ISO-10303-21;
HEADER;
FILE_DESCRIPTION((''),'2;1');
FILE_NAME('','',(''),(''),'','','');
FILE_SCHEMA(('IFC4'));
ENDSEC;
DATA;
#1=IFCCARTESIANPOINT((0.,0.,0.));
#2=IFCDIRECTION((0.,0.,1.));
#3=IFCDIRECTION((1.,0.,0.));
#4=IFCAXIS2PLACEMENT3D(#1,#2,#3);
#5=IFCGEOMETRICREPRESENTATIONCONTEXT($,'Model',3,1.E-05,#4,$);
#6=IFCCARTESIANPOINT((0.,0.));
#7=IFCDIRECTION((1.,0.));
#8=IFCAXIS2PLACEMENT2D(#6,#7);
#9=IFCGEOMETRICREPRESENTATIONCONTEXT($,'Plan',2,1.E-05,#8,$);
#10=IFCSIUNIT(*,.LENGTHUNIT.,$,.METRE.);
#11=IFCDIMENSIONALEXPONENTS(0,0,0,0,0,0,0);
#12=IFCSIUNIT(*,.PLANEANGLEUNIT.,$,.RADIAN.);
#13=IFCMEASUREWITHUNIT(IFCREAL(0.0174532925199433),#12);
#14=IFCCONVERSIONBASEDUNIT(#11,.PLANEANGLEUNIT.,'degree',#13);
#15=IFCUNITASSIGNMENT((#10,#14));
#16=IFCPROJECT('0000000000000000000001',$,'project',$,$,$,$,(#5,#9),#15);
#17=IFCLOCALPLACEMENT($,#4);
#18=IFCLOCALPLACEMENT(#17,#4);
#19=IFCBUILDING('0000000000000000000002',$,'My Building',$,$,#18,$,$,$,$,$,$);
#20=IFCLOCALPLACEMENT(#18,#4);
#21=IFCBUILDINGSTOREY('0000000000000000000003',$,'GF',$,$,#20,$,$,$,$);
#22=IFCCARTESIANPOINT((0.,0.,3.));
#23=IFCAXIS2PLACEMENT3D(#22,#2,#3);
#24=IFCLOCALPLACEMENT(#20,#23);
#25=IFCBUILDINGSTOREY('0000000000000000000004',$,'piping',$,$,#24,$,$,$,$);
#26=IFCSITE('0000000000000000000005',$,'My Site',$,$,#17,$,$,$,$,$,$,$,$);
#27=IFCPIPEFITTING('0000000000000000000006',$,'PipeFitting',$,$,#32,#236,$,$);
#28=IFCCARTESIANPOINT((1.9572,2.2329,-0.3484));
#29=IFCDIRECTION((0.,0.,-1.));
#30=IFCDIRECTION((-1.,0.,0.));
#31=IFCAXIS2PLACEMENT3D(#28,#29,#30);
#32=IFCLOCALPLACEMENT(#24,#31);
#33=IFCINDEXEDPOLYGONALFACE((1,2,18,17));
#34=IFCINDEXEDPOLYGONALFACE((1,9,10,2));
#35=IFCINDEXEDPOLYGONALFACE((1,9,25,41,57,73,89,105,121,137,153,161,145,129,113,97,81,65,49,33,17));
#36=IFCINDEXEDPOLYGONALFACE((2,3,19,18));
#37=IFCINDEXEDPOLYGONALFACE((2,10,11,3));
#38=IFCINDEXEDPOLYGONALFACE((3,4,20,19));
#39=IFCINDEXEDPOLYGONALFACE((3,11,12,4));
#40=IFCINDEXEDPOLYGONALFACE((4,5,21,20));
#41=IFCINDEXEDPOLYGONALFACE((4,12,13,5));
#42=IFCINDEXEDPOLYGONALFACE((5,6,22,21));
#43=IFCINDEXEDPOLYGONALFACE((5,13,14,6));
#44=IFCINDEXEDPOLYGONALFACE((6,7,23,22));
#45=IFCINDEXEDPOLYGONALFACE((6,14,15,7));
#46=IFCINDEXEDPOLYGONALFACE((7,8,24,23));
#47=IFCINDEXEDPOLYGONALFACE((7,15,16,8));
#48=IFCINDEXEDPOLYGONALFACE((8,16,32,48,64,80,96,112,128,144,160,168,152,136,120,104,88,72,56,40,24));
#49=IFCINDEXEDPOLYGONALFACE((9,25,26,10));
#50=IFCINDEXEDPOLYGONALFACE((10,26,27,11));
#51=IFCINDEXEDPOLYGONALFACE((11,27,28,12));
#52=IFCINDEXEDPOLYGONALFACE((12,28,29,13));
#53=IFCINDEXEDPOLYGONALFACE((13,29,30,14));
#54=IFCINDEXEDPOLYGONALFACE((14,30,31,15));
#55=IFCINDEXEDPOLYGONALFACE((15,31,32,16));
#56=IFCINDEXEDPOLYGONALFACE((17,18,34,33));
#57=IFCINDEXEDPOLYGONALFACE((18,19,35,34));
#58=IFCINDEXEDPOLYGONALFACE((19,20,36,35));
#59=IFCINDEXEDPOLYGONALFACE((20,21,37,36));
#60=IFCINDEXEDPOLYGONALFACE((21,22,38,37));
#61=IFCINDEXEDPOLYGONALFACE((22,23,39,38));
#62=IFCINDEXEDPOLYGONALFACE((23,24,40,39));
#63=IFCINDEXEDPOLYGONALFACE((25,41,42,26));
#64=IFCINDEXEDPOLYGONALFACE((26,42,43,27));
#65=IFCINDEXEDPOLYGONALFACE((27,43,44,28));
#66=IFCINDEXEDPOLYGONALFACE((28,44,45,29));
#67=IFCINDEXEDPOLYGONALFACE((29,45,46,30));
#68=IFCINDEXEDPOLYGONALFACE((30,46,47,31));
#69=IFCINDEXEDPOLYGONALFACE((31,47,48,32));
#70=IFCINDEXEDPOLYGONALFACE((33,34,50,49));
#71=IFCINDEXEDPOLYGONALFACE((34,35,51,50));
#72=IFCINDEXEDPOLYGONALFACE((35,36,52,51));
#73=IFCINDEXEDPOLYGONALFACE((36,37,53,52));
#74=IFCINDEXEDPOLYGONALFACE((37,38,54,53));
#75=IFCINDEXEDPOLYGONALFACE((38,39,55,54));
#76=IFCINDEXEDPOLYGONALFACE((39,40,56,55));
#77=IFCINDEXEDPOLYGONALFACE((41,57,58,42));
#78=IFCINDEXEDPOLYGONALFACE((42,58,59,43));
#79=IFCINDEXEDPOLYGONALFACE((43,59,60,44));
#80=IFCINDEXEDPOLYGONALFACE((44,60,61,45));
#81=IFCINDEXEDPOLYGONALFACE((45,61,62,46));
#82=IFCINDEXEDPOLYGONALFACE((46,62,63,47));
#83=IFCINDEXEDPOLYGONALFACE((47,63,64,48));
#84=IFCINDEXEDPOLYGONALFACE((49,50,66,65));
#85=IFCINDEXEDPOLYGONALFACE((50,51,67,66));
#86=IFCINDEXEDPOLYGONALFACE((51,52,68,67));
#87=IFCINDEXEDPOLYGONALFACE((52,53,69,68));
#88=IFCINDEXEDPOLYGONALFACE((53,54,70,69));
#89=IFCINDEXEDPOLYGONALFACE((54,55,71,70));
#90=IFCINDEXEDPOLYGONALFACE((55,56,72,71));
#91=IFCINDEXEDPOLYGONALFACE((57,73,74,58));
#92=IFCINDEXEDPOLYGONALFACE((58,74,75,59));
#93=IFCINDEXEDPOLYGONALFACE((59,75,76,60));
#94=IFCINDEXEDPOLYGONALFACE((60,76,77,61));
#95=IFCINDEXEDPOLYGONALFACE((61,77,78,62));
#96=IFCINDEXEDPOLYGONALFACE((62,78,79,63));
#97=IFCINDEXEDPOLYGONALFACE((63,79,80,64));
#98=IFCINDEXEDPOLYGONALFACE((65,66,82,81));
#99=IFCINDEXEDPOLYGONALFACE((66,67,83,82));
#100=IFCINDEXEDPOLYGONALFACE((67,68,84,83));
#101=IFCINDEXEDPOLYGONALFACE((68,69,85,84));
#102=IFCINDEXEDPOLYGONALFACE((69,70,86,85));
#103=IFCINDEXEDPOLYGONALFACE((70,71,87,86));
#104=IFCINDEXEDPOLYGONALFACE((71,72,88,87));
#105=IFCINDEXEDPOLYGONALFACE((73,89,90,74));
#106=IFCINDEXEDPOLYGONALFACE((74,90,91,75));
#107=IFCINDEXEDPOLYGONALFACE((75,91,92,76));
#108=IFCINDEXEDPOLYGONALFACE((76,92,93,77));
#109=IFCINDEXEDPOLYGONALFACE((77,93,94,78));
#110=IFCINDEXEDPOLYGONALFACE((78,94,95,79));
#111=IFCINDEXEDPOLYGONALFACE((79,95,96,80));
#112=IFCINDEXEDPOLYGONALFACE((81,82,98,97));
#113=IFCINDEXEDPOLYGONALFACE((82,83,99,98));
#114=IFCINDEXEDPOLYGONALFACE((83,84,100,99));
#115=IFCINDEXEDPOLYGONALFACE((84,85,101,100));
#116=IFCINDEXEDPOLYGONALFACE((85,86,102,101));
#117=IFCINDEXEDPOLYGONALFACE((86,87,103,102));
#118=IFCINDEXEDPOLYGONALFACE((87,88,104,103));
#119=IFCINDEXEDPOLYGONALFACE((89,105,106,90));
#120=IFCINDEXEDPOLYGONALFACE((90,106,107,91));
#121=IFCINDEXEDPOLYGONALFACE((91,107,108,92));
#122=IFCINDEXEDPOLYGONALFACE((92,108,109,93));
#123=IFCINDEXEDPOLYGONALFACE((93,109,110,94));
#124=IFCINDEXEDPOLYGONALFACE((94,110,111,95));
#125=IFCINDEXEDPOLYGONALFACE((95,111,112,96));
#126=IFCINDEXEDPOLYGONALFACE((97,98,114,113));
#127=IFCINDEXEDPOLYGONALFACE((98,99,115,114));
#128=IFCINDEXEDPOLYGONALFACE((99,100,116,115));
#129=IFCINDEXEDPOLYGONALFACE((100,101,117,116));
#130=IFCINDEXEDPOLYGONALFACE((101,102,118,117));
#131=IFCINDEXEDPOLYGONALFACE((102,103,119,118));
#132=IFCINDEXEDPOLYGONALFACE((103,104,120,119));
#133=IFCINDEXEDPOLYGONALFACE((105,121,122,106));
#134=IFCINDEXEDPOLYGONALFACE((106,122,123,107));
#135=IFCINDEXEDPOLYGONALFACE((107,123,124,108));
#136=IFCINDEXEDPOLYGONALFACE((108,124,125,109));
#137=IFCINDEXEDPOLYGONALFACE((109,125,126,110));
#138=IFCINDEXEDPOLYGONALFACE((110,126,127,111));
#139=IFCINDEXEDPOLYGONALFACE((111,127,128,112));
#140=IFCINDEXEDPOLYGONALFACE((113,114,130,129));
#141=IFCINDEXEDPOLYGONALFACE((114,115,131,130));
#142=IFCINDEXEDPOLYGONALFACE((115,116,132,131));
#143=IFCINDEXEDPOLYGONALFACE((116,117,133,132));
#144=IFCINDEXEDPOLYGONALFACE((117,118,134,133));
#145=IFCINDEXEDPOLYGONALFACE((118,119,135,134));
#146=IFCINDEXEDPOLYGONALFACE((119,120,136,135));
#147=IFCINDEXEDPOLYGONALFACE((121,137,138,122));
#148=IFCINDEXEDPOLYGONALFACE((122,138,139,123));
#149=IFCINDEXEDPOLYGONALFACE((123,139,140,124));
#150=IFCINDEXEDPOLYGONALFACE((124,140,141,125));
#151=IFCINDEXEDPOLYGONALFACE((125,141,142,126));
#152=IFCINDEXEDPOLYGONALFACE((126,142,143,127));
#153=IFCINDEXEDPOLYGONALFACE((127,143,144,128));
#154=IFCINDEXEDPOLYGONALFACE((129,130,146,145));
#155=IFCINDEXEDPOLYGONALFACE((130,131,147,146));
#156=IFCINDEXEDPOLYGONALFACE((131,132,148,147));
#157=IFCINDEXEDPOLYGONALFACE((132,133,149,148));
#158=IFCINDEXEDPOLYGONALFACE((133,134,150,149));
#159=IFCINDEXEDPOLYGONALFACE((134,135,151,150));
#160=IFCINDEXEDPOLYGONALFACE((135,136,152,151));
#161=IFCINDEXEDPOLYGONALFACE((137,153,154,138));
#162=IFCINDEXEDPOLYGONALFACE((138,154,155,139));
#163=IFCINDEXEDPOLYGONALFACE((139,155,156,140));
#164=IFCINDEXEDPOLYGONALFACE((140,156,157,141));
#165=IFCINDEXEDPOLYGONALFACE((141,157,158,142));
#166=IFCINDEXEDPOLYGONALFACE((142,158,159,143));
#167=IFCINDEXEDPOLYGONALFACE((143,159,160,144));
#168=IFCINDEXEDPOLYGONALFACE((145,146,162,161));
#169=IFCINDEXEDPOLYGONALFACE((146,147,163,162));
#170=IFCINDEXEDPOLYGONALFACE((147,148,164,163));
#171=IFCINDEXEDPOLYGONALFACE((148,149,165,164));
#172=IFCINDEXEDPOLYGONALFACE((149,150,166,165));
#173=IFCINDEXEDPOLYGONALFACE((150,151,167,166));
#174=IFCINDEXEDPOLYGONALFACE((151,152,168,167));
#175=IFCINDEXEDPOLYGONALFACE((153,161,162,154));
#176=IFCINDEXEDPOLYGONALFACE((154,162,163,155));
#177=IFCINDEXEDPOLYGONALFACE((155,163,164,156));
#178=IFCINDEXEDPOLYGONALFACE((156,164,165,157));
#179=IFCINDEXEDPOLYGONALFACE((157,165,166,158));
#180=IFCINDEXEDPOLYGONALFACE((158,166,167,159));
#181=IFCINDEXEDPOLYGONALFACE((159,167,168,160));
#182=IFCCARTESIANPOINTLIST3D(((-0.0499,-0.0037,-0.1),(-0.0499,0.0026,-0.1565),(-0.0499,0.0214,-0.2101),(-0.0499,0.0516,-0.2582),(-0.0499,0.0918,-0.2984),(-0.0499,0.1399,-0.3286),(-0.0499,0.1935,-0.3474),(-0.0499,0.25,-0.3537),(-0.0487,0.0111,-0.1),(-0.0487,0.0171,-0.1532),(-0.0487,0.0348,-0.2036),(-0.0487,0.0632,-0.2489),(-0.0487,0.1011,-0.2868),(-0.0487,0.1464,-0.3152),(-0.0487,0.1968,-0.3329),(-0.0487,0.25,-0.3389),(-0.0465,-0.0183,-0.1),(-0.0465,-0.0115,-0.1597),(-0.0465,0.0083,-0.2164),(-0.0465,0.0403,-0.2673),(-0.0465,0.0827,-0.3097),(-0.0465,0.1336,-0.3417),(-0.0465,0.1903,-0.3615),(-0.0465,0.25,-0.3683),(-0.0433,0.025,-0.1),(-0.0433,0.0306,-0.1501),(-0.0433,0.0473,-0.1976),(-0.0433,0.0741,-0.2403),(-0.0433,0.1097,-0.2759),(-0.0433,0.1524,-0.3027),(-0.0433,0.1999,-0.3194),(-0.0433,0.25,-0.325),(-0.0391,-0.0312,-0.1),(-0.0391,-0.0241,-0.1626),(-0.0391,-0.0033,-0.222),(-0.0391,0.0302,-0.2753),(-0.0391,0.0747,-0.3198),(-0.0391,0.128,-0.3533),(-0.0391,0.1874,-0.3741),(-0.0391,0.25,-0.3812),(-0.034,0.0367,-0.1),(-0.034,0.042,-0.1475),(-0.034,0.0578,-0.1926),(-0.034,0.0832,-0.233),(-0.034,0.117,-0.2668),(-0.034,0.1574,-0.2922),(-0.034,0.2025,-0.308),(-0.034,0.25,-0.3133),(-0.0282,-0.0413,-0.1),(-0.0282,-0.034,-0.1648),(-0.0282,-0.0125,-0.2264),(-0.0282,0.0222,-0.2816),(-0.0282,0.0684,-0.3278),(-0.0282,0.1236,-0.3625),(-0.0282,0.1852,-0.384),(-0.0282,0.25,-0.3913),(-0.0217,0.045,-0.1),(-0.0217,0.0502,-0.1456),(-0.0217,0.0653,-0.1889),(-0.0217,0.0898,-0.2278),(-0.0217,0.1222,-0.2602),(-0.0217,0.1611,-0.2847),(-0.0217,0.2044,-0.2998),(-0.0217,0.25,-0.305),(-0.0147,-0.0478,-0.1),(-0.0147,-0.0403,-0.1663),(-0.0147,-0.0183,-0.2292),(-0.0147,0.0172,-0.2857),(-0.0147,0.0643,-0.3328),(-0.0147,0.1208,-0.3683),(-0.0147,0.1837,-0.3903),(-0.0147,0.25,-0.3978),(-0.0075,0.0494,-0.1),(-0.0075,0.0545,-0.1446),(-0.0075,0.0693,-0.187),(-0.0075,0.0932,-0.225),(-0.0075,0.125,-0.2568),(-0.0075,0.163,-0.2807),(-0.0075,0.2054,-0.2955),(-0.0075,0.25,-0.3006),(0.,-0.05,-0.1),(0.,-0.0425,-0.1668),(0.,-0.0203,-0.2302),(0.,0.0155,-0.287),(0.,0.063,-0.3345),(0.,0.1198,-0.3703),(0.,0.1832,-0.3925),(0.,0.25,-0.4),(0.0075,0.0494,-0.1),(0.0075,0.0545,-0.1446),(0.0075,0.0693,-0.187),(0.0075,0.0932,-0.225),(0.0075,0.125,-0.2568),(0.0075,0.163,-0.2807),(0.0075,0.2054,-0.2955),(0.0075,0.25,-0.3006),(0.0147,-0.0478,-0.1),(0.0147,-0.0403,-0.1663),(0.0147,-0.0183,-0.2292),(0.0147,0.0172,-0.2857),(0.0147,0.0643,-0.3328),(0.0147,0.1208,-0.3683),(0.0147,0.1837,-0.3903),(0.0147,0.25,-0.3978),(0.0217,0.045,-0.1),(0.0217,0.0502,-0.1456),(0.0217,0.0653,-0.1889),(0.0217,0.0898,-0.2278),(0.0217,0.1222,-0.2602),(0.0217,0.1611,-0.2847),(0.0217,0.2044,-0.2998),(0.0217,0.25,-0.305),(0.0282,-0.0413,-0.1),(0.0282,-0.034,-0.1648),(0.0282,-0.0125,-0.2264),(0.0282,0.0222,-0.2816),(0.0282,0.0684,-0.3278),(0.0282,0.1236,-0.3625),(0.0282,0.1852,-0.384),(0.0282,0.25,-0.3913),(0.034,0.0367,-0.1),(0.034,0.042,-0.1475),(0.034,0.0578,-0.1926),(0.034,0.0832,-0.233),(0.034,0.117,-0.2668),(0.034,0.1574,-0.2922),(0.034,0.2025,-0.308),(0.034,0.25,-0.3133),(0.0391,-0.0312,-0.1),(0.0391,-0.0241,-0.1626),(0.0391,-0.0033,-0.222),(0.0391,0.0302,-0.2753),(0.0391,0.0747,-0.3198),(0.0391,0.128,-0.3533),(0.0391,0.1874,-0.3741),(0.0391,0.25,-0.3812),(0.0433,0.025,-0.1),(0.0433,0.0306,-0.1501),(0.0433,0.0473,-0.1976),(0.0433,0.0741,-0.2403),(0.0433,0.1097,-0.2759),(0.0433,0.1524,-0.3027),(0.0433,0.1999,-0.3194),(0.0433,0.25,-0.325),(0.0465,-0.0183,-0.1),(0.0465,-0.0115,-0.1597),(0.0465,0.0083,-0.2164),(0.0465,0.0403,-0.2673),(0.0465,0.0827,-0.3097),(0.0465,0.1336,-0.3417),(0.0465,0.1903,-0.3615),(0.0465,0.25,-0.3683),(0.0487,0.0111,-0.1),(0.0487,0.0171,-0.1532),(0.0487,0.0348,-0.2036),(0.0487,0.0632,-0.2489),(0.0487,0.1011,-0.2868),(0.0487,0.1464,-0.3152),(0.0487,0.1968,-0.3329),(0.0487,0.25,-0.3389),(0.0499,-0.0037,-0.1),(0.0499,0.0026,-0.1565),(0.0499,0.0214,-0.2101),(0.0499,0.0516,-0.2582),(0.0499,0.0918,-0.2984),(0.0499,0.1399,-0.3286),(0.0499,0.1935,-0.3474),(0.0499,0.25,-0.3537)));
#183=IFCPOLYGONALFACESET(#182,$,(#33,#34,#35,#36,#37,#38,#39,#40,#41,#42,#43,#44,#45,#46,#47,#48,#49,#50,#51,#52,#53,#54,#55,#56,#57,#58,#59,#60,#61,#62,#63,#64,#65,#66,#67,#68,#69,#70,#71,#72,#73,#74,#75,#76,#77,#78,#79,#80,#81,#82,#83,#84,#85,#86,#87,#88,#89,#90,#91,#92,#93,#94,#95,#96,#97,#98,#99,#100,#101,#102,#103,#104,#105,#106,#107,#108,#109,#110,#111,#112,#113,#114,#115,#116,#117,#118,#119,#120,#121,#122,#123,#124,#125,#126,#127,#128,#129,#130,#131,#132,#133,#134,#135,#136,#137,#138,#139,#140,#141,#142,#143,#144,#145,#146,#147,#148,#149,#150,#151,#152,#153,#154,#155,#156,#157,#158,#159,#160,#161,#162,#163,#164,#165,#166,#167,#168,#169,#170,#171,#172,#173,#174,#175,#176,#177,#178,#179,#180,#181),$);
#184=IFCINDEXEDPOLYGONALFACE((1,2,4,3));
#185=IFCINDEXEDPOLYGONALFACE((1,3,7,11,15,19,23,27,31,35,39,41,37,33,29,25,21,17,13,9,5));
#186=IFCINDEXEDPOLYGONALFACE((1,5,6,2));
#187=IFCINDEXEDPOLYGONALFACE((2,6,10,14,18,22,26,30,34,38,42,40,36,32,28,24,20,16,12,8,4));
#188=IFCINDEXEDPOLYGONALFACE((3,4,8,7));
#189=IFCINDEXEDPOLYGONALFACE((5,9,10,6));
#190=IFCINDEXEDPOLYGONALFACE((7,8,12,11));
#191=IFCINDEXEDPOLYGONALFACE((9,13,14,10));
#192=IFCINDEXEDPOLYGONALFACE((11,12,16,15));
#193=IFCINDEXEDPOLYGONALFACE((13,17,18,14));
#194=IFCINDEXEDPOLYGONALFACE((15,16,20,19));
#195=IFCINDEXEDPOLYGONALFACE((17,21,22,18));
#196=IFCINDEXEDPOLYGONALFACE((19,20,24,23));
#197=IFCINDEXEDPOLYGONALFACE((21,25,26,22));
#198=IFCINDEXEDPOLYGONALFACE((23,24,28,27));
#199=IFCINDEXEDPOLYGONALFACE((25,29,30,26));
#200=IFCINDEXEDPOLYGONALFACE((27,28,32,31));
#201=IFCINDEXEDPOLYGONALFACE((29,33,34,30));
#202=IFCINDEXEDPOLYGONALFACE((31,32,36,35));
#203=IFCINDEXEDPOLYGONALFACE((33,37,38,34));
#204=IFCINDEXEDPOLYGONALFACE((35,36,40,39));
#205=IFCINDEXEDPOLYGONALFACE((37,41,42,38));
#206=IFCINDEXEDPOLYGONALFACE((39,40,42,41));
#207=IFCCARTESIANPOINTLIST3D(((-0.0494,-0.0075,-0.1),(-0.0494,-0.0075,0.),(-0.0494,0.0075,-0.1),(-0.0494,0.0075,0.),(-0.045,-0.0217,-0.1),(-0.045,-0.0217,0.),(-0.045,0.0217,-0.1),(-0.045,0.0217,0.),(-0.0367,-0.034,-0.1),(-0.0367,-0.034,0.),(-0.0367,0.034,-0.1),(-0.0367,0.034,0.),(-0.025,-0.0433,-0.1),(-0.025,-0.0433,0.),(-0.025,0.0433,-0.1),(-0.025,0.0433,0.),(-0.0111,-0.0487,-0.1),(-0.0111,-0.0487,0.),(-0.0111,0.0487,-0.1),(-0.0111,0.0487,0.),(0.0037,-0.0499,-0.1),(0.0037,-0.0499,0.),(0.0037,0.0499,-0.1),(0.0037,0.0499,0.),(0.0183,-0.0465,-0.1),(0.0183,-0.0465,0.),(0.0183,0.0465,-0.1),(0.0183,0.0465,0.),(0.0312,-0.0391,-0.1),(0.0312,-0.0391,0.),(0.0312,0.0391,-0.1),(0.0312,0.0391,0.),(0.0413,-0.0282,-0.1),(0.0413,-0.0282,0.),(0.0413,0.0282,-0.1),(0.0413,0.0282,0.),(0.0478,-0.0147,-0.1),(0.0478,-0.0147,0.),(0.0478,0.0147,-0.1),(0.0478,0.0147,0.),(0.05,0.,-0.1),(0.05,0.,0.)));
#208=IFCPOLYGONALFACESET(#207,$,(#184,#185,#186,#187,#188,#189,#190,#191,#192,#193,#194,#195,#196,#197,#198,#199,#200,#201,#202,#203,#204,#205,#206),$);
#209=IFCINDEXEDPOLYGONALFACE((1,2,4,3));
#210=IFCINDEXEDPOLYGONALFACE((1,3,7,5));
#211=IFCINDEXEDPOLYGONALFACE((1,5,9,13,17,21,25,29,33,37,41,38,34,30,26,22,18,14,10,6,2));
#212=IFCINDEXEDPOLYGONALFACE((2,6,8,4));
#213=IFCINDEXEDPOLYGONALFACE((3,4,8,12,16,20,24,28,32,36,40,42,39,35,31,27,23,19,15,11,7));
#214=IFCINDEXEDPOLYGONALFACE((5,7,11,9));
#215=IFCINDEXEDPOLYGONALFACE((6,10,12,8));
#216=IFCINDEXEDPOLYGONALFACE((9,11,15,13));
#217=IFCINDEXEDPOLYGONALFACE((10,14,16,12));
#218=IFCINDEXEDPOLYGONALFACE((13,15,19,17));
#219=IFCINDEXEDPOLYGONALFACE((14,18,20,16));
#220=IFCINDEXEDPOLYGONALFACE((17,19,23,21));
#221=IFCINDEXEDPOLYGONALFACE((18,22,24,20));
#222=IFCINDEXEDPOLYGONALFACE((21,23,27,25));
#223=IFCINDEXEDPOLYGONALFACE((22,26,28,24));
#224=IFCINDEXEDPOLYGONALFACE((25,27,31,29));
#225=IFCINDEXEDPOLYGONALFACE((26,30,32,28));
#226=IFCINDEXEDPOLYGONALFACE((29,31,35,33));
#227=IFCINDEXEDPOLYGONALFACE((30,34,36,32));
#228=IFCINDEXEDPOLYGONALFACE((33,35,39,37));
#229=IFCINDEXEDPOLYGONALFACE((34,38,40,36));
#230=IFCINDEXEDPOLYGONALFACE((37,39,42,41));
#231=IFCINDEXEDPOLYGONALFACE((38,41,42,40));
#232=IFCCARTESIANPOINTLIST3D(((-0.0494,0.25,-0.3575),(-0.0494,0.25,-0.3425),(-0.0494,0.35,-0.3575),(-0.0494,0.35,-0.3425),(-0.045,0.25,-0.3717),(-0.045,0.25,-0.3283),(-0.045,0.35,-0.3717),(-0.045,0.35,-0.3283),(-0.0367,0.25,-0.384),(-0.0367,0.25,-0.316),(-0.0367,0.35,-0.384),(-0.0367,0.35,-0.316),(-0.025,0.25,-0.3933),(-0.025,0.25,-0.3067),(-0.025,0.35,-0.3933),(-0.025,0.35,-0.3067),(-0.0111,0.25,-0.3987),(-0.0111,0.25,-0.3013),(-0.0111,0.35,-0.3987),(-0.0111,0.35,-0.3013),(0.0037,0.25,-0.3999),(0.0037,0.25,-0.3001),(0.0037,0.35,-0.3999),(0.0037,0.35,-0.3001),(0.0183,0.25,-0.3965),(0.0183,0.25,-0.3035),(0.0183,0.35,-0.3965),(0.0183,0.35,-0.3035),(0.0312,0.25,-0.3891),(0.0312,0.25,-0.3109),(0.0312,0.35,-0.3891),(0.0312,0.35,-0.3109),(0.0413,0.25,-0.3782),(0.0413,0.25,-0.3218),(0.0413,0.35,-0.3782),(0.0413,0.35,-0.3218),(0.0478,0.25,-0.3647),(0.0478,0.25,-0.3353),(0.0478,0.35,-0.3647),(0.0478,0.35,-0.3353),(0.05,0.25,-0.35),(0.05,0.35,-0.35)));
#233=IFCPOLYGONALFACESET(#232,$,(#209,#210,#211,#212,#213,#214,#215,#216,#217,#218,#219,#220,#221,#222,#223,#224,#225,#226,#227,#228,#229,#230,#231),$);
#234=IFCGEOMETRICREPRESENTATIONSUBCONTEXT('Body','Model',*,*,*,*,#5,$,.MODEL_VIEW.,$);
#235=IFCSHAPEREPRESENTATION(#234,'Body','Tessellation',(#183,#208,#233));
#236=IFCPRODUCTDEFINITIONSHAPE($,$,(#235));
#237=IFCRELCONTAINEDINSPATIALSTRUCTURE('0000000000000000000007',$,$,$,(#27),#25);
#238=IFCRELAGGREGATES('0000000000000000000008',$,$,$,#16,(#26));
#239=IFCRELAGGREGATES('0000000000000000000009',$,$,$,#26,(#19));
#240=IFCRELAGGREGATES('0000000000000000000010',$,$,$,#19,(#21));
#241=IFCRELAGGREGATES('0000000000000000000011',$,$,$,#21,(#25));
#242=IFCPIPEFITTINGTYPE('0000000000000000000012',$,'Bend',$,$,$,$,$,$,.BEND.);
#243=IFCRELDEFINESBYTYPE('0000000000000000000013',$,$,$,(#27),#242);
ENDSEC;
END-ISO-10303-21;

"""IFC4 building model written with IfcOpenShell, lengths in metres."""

from ifc_helpers import new_model, entity, si_unit, converted_unit, frame, origin_with_axes, origin_2d_with_axis, place, context, subcontext, project, spatial, circle, extrude, source, transform, mapped, type_object, type_shapes, element, save


model = new_model("IFC4")

# Units and contexts
model_context = context("Model", 3, precision=1e-05, world=origin_with_axes())
plan_context = context("Plan", 2, precision=1e-05, world=origin_2d_with_axis())
body_context = subcontext(model_context, "Body", "Model", "MODEL_VIEW")
ifc_project = project(units=[si_unit("LENGTHUNIT", "METRE"), converted_unit("PLANEANGLEUNIT", "degree", entity("IfcReal", 0.0174532925199433), si_unit("PLANEANGLEUNIT", "RADIAN"), dimensions=[0, 0, 0, 0, 0, 0, 0])], contexts=[model_context, plan_context])

# Site, building, storeys
site_placement = place(None, origin_with_axes())
site = spatial("IfcSite", under=ifc_project, at=site_placement, Name="My Site")
building_placement = place(site_placement, origin_with_axes())
building = spatial("IfcBuilding", under=site, at=building_placement, Name="My Building")
storey_1_placement = place(building_placement, origin_with_axes())
storey_1 = spatial("IfcBuildingStorey", under=building, at=storey_1_placement, Name="GF")
storey_2_placement = place(storey_1_placement, frame((0.0, 0.0, 3.0), z_axis=(0.0, 0.0, 1.0), x_axis=(1.0, 0.0, 0.0)))
storey_2 = spatial("IfcBuildingStorey", under=storey_1, at=storey_2_placement, Name="piping")

# Pipe fitting
pipe_fitting_type = type_object("IfcPipeFittingType", Name="Bend", PredefinedType="BEND")
shared_shape = source(origin_with_axes(), body_context, "Body", "SolidModel", [
    entity("IfcSweptDiskSolid", entity("IfcIndexedPolyCurve", entity("IfcCartesianPointList3D", [[0.0, 0.0, -0.1], [0.0, 0.0732, -0.2768], [0.0, 0.25, -0.35]]), [entity("IfcArcIndex", [1, 2, 3])]), 0.05),
    extrude(circle(Radius=0.05), origin_with_axes(), (0.0, 0.0, -1.0), 0.1),
    extrude(circle(Radius=0.05), frame((0.0, 0.25, -0.35), z_axis=(0.0, 1.0, 0.0), x_axis=(1.0, 0.0, 0.0)), (0.0, 0.0, 1.0), 0.1),
])
type_shapes(pipe_fitting_type, [shared_shape])
for number, where, z_axis, x_axis, name in (
    (1, (1.9572, 2.2329, -0.3484), (0.0, 0.0, -1.0), (-1.0, 0.0, 0.0), "PipeFitting"),
):
    element("IfcPipeFitting", number, at=place(storey_2_placement, frame(where, z_axis=z_axis, x_axis=x_axis)), inside=storey_2, type_object=pipe_fitting_type, Name=name, context=body_context, shape_type="MappedRepresentation", body=[
        mapped(shared_shape, transform((0.0, 0.0, 0.0), x_axis=(1.0, 0.0, 0.0), y_axis=(0.0, 1.0, 0.0), z_axis=(0.0, 0.0, 1.0), scale=1.0)),
    ])

save(model, "model.ifc")
